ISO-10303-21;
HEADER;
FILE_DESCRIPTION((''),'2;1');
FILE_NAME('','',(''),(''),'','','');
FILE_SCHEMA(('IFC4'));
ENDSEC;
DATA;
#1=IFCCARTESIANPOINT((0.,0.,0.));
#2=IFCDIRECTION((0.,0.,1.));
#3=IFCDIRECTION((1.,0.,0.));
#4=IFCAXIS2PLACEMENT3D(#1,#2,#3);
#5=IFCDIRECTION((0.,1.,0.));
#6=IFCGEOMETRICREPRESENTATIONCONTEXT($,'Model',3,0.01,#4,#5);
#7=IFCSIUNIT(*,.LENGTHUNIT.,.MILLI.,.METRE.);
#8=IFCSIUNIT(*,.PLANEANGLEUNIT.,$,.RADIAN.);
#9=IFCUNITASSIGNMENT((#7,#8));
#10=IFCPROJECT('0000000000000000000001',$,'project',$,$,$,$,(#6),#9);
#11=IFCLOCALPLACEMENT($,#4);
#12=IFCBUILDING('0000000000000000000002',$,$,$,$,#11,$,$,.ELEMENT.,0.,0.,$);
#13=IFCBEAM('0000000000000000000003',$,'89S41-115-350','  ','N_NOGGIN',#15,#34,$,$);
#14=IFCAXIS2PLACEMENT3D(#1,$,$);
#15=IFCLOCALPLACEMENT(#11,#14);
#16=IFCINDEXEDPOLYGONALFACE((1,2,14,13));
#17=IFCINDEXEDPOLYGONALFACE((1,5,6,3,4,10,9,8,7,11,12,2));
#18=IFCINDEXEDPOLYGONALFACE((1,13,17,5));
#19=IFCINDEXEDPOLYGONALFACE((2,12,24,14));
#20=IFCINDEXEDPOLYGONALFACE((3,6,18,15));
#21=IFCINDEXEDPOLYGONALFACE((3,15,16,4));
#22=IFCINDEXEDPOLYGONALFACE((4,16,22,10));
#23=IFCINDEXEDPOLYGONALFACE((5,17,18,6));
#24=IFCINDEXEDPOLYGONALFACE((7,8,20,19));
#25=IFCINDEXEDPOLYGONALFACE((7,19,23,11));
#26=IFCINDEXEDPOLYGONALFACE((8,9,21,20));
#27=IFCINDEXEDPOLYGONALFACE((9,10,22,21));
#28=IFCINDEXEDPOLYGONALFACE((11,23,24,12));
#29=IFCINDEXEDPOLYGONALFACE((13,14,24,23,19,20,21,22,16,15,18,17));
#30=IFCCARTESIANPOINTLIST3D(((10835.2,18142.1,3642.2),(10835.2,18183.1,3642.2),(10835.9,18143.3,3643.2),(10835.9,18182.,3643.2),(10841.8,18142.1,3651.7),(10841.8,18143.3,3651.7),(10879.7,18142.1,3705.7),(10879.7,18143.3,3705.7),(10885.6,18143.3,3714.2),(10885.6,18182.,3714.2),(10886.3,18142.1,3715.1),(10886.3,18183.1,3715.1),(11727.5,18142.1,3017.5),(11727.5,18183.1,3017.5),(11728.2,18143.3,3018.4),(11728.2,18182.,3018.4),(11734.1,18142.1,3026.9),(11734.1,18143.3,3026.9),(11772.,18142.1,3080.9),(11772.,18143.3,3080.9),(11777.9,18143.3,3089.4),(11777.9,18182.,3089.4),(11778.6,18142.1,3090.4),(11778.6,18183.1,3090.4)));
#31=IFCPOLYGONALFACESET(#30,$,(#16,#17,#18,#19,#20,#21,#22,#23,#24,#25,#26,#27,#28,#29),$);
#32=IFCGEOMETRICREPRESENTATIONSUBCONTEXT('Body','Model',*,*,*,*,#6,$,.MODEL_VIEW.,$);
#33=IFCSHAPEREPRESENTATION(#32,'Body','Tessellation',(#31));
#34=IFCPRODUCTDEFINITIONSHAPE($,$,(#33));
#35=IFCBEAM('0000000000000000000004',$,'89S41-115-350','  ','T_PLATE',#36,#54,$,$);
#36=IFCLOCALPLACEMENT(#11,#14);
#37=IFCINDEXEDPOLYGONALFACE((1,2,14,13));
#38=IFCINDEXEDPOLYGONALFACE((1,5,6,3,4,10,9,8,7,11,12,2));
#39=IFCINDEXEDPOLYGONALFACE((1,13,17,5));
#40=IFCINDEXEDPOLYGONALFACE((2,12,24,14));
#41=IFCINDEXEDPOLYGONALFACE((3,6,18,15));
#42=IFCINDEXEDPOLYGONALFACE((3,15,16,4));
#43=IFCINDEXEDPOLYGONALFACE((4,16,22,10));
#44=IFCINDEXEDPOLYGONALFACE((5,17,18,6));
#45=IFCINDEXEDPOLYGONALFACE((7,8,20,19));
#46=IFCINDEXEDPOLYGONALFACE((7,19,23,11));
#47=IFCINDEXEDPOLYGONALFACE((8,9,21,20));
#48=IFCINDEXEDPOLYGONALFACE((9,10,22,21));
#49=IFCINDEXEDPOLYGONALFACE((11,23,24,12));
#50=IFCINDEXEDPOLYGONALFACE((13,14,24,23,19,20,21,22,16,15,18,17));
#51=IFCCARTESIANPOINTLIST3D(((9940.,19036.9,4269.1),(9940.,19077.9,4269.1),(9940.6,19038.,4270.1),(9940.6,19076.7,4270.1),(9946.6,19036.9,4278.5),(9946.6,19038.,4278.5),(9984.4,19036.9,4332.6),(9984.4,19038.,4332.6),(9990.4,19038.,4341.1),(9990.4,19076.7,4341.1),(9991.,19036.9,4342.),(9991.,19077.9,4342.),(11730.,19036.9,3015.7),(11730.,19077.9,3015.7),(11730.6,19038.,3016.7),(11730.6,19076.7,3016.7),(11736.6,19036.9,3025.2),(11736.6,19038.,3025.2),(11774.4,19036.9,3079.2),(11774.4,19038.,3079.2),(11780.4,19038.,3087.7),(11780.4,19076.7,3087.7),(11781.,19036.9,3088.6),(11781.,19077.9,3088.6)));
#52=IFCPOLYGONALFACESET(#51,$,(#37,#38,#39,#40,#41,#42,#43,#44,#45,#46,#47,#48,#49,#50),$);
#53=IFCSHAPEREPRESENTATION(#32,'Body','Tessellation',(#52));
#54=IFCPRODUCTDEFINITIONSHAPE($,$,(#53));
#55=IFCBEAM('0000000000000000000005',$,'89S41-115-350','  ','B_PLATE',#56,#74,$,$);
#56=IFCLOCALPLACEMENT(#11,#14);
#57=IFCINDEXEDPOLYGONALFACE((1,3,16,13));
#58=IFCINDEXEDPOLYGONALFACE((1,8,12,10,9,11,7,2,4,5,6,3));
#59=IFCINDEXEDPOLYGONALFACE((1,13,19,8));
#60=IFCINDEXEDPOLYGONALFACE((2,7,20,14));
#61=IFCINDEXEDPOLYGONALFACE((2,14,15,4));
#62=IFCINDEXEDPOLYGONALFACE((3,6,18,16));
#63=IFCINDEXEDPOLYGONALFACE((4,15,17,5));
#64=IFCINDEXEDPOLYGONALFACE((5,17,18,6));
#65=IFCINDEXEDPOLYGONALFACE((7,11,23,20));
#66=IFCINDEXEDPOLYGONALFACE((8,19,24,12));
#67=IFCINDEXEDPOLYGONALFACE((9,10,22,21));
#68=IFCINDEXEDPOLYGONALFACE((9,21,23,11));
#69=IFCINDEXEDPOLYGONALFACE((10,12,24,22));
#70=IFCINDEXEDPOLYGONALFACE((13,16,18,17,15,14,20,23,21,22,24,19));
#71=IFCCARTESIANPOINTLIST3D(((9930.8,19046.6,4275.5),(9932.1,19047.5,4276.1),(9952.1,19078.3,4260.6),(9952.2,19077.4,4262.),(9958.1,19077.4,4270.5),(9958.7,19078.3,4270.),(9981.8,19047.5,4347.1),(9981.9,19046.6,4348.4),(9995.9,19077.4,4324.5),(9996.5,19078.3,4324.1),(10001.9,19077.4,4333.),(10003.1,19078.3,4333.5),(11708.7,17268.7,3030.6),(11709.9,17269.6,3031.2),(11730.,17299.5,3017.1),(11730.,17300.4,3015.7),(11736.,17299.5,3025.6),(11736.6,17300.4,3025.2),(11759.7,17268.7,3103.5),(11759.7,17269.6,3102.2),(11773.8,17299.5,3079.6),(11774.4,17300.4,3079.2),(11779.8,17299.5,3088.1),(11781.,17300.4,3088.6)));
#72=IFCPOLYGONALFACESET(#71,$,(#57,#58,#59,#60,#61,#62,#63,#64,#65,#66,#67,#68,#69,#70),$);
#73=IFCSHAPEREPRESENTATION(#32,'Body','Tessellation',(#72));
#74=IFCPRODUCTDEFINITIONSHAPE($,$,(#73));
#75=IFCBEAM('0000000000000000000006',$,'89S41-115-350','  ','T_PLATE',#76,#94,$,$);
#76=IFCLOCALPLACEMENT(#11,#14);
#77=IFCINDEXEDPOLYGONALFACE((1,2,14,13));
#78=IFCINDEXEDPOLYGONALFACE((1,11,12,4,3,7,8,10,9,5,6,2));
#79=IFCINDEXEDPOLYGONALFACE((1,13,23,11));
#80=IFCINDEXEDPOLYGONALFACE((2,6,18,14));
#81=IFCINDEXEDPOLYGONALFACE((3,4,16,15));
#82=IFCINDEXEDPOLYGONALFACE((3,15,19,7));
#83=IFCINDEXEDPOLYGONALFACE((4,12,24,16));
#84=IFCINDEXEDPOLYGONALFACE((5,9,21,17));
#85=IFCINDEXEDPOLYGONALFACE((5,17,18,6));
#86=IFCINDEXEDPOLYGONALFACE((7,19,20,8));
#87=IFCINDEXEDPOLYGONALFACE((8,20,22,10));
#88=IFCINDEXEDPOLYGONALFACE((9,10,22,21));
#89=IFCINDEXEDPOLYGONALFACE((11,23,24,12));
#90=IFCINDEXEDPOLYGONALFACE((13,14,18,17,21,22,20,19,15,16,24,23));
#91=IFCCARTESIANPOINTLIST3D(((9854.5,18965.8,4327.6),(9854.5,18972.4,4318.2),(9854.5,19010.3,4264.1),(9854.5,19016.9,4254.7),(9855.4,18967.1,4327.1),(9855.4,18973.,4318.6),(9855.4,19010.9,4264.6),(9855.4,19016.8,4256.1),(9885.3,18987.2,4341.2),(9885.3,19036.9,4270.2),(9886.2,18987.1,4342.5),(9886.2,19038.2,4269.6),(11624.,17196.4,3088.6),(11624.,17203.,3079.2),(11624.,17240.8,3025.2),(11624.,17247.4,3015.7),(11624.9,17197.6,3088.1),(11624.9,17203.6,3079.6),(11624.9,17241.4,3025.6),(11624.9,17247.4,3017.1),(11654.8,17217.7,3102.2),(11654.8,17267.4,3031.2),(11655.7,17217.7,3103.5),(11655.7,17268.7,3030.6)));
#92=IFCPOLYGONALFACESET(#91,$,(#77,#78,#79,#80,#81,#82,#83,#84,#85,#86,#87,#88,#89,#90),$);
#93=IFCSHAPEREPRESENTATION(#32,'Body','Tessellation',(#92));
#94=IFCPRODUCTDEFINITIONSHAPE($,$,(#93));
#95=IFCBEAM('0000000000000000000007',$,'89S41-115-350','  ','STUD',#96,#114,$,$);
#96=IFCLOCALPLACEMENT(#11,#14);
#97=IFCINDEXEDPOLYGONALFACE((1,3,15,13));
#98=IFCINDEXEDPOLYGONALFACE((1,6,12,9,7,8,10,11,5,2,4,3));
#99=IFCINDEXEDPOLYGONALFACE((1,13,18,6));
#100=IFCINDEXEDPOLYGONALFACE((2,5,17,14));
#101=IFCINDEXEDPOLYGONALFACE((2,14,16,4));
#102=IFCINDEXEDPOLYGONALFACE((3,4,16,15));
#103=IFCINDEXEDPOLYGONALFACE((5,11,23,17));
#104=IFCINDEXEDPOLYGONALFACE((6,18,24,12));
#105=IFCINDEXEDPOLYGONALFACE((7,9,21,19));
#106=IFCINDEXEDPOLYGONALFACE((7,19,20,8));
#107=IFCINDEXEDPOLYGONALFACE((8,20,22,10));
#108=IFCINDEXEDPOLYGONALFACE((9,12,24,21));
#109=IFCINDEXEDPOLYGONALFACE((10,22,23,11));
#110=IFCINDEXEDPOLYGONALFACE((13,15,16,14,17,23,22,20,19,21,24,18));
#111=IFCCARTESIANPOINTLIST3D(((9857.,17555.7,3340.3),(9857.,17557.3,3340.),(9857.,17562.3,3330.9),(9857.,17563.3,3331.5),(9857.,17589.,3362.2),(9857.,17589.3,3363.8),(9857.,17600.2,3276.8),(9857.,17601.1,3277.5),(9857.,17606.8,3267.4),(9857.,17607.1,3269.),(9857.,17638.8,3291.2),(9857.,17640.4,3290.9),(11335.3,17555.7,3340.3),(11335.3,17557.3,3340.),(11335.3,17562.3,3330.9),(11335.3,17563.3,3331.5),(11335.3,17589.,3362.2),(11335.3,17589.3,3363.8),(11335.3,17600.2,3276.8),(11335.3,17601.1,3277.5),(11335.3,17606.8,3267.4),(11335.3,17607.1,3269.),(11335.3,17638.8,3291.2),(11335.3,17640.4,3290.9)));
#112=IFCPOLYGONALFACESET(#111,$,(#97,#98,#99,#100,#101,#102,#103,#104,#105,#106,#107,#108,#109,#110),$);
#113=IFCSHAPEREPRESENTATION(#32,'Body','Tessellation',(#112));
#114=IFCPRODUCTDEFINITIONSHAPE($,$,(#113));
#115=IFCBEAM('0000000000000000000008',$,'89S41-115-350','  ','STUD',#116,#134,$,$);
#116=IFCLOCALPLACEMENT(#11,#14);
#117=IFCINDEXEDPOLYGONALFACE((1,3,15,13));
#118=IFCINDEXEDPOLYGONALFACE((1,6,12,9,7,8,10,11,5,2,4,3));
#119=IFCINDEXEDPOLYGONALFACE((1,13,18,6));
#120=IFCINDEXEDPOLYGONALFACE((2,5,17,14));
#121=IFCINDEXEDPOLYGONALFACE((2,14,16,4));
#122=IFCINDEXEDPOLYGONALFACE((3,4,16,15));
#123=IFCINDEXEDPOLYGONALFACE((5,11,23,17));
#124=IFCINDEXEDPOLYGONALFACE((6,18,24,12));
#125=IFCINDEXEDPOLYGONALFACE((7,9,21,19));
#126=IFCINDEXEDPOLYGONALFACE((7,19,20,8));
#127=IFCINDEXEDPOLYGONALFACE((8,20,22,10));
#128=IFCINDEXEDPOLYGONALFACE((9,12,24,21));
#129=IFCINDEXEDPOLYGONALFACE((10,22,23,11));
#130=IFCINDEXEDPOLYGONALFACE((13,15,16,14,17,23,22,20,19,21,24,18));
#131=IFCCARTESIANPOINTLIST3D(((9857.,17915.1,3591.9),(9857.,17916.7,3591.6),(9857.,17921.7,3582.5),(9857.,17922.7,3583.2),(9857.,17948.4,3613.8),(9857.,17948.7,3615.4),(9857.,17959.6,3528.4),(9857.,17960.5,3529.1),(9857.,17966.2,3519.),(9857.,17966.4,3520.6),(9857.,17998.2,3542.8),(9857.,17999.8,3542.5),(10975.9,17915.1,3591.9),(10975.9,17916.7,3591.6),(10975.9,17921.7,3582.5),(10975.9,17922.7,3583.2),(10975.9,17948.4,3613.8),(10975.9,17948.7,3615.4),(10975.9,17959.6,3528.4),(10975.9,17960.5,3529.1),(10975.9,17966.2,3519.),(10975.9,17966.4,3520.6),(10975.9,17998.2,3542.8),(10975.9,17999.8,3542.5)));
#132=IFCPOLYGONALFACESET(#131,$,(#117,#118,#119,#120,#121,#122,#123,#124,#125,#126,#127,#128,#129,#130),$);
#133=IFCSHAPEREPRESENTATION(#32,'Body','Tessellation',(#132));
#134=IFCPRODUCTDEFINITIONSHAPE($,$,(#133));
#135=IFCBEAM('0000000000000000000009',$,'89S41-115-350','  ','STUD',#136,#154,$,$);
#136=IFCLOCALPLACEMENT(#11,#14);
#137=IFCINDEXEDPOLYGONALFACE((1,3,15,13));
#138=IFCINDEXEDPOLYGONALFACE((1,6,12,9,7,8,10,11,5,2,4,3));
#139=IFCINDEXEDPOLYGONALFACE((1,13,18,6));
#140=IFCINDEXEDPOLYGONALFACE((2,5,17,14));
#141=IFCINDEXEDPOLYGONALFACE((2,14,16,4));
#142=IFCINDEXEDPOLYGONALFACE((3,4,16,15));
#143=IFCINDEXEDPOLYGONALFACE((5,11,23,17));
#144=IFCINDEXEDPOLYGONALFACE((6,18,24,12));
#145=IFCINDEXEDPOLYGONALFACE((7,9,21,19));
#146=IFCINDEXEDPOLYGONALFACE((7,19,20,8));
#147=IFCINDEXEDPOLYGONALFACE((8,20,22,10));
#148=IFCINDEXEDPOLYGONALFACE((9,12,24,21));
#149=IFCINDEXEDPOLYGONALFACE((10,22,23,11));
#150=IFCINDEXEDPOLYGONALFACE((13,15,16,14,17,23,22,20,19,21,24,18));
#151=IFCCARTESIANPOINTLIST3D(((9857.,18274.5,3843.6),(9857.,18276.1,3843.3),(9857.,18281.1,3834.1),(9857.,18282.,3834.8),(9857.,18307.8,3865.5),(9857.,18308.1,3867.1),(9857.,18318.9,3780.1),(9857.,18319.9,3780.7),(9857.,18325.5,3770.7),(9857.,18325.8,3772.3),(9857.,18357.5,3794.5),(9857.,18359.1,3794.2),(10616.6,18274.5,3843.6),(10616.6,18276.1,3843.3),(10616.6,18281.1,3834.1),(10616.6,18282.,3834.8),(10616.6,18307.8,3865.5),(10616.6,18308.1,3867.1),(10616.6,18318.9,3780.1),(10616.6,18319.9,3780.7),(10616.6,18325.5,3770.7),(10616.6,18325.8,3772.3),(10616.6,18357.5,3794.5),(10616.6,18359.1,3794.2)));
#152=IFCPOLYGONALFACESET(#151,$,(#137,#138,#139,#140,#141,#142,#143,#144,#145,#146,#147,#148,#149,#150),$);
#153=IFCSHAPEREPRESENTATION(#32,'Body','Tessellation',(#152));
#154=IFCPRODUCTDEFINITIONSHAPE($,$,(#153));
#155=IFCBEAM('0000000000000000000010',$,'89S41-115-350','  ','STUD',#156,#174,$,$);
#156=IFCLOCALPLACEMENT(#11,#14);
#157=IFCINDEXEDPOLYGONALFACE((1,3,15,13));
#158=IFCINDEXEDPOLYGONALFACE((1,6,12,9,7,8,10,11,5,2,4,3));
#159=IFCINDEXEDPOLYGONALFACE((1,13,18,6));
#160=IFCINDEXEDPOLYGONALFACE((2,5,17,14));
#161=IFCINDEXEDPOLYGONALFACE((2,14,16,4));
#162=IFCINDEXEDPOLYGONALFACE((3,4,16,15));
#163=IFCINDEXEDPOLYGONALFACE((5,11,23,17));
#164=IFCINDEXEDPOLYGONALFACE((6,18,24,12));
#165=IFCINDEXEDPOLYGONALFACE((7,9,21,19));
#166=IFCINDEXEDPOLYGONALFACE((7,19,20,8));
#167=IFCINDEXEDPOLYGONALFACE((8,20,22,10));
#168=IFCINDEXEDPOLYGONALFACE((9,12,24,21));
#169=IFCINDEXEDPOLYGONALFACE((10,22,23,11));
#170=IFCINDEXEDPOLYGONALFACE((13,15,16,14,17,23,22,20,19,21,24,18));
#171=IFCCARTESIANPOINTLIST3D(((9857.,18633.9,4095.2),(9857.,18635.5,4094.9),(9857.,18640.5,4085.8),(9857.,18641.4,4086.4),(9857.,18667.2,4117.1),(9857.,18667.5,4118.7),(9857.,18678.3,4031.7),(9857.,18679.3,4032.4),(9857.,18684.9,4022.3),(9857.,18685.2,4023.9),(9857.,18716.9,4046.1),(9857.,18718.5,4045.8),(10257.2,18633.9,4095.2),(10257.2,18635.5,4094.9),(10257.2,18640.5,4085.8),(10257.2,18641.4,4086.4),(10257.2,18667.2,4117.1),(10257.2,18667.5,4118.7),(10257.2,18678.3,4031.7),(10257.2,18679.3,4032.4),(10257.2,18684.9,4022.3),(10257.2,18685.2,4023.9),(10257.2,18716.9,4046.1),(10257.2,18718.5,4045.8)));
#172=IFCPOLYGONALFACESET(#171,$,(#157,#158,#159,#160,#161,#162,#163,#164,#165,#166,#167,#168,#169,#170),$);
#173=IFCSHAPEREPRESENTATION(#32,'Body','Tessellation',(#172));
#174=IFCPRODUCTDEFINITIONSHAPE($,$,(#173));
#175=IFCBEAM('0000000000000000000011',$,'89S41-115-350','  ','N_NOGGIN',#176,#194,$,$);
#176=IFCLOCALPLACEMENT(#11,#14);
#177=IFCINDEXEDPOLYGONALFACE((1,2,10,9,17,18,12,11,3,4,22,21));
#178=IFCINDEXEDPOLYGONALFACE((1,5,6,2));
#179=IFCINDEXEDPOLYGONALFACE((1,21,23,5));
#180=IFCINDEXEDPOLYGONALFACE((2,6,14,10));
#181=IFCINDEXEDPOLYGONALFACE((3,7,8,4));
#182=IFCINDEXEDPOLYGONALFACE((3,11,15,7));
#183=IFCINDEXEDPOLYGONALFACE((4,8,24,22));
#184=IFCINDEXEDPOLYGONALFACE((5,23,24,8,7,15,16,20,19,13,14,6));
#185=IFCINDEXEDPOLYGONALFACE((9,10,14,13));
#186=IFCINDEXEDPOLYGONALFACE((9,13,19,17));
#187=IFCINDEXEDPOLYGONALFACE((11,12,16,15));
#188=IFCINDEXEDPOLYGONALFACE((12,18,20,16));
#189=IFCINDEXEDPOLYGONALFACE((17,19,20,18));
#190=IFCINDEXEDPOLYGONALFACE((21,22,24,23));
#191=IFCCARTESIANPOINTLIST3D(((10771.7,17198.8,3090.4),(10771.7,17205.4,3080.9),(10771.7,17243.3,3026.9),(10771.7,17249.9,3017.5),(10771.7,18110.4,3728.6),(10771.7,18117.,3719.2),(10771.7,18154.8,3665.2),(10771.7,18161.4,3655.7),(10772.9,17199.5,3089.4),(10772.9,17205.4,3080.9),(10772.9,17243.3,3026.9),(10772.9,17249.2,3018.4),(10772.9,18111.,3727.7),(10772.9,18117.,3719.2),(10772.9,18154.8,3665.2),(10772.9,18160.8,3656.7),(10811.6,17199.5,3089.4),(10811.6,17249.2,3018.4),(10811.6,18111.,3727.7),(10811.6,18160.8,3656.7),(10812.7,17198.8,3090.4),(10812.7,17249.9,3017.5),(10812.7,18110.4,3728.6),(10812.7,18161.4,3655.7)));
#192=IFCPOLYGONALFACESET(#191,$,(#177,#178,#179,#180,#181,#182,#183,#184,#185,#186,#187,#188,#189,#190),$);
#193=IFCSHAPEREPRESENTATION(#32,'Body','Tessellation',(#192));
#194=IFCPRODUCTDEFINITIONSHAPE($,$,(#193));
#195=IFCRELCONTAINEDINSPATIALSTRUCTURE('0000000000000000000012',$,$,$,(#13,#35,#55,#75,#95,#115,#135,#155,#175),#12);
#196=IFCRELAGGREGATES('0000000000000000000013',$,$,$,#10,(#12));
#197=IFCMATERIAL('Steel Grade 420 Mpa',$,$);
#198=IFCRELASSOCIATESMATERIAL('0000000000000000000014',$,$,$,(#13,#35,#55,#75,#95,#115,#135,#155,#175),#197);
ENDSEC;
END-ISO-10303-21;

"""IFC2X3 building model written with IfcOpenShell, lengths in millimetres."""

from ifc_helpers import new_model, si_unit, direction, frame, origin, origin_with_axes, origin_2d_with_axis, place, context, subcontext, project, spatial, c_section, extrude, source, transform, mapped, material, element, save


model = new_model("IFC2X3")

# Units and contexts
model_context = context("Model", 3, precision=0.01, world=origin_with_axes(), true_north=direction((0.0, 1.0, 0.0)))
body_context = subcontext(model_context, "Body", "Model", "MODEL_VIEW")
ifc_project = project(units=[si_unit("LENGTHUNIT", "METRE", prefix="MILLI"), si_unit("PLANEANGLEUNIT", "RADIAN")], contexts=[model_context])

# Building
building_placement = place(None, origin_with_axes())
building = spatial("IfcBuilding", under=ifc_project, at=building_placement, CompositionType="ELEMENT", ElevationOfRefHeight=0.0, ElevationOfTerrain=0.0)

# Shared definitions
ifc_material = material(Name="Steel Grade 420 Mpa")

# Beams
shared_shape_1 = source(origin(), body_context, "Body", "SweptSolid", [
    extrude(c_section(Depth=89.0, Width=41.0, WallThickness=1.1, Girth=11.5, at=origin_2d_with_axis()), origin_with_axes(), (0.0, 0.0, 1.0), 1089.3),
])
beam_1_placement = place(None, frame((10860.8, 18162.6, 3678.7), z_axis=(0.819152, 0.0, -0.573576), x_axis=(0.0, -1.0, 0.0)))
element("IfcBeam", 1, at=beam_1_placement, inside=building, material=ifc_material, Name="89S41-115-350", Description="  ", ObjectType="N_NOGGIN", context=body_context, shape_type="MappedRepresentation", body=[
    mapped(shared_shape_1, transform((0.0, 0.0, 0.0), scale=1.0)),
])
shared_shape_2 = source(origin(), body_context, "Body", "SweptSolid", [
    extrude(c_section(Depth=89.0, Width=41.0, WallThickness=1.1, Girth=11.5, at=origin_2d_with_axis()), origin_with_axes(), (0.0, 0.0, 1.0), 2185.2),
])
beam_2_placement = place(None, frame((9965.5, 19057.4, 4305.6), z_axis=(0.819152, 0.0, -0.573576), x_axis=(0.0, -1.0, 0.0)))
element("IfcBeam", 2, at=beam_2_placement, inside=building, material=ifc_material, Name="89S41-115-350", Description="  ", ObjectType="T_PLATE", context=body_context, shape_type="MappedRepresentation", body=[
    mapped(shared_shape_2, transform((0.0, 0.0, 0.0), scale=1.0)),
])
shared_shape_3 = source(origin(), body_context, "Body", "SweptSolid", [
    extrude(c_section(Depth=89.0, Width=41.0, WallThickness=1.1, Girth=11.5, at=origin_2d_with_axis()), origin_with_axes(), (0.0, 0.0, 1.0), 2805.6),
])
beam_3_placement = place(None, frame((9967.0, 19062.4, 4304.5), z_axis=(0.633687, -0.633687, -0.443713), x_axis=(0.519086, 0.773589, -0.363468)))
element("IfcBeam", 3, at=beam_3_placement, inside=building, material=ifc_material, Name="89S41-115-350", Description="  ", ObjectType="B_PLATE", context=body_context, shape_type="MappedRepresentation", body=[
    mapped(shared_shape_3, transform((0.0, 0.0, 0.0), scale=1.0)),
])
shared_shape_4 = source(origin(), body_context, "Body", "SweptSolid", [
    extrude(c_section(Depth=89.0, Width=41.0, WallThickness=1.1, Girth=11.5, at=origin_2d_with_axis()), origin_with_axes(), (0.0, 0.0, 1.0), 2792.3),
])
beam_4_placement = place(None, frame((9870.4, 19002.0, 4298.6), z_axis=(0.633687, -0.633687, -0.443713), x_axis=(-0.773589, -0.519086, -0.363468)))
element("IfcBeam", 4, at=beam_4_placement, inside=building, material=ifc_material, Name="89S41-115-350", Description="  ", ObjectType="T_PLATE", context=body_context, shape_type="MappedRepresentation", body=[
    mapped(shared_shape_4, transform((0.0, 0.0, 0.0), scale=1.0)),
])
shared_shape_5 = source(origin(), body_context, "Body", "SweptSolid", [
    extrude(c_section(Depth=89.0, Width=41.0, WallThickness=1.1, Girth=11.5, at=origin_2d_with_axis()), origin_with_axes(), (0.0, 0.0, 1.0), 1478.3),
])
beam_5_placement = place(None, frame((9857.0, 17598.1, 3315.6), z_axis=(1.0, 0.0, 0.0), x_axis=(0.0, -0.819152, -0.573576)))
element("IfcBeam", 5, at=beam_5_placement, inside=building, material=ifc_material, Name="89S41-115-350", Description="  ", ObjectType="STUD", context=body_context, shape_type="MappedRepresentation", body=[
    mapped(shared_shape_5, transform((0.0, 0.0, 0.0), scale=1.0)),
])
shared_shape_6 = source(origin(), body_context, "Body", "SweptSolid", [
    extrude(c_section(Depth=89.0, Width=41.0, WallThickness=1.1, Girth=11.5, at=origin_2d_with_axis()), origin_with_axes(), (0.0, 0.0, 1.0), 1118.9),
])
beam_6_placement = place(None, frame((9857.0, 17957.4, 3567.2), z_axis=(1.0, 0.0, 0.0), x_axis=(0.0, -0.819152, -0.573576)))
element("IfcBeam", 6, at=beam_6_placement, inside=building, material=ifc_material, Name="89S41-115-350", Description="  ", ObjectType="STUD", context=body_context, shape_type="MappedRepresentation", body=[
    mapped(shared_shape_6, transform((0.0, 0.0, 0.0), scale=1.0)),
])
shared_shape_7 = source(origin(), body_context, "Body", "SweptSolid", [
    extrude(c_section(Depth=89.0, Width=41.0, WallThickness=1.1, Girth=11.5, at=origin_2d_with_axis()), origin_with_axes(), (0.0, 0.0, 1.0), 759.5),
])
beam_7_placement = place(None, frame((9857.0, 18316.8, 3818.9), z_axis=(1.0, 0.0, 0.0), x_axis=(0.0, -0.819152, -0.573576)))
element("IfcBeam", 7, at=beam_7_placement, inside=building, material=ifc_material, Name="89S41-115-350", Description="  ", ObjectType="STUD", context=body_context, shape_type="MappedRepresentation", body=[
    mapped(shared_shape_7, transform((0.0, 0.0, 0.0), scale=1.0)),
])
shared_shape_8 = source(origin(), body_context, "Body", "SweptSolid", [
    extrude(c_section(Depth=89.0, Width=41.0, WallThickness=1.1, Girth=11.5, at=origin_2d_with_axis()), origin_with_axes(), (0.0, 0.0, 1.0), 400.2),
])
beam_8_placement = place(None, frame((9857.0, 18676.2, 4070.5), z_axis=(1.0, 0.0, 0.0), x_axis=(0.0, -0.819152, -0.573576)))
element("IfcBeam", 8, at=beam_8_placement, inside=building, material=ifc_material, Name="89S41-115-350", Description="  ", ObjectType="STUD", context=body_context, shape_type="MappedRepresentation", body=[
    mapped(shared_shape_8, transform((0.0, 0.0, 0.0), scale=1.0)),
])
shared_shape_9 = source(origin(), body_context, "Body", "SweptSolid", [
    extrude(c_section(Depth=89.0, Width=41.0, WallThickness=1.1, Girth=11.5, at=origin_2d_with_axis()), origin_with_axes(), (0.0, 0.0, 1.0), 1112.8),
])
beam_9_placement = place(None, frame((10792.2, 18135.9, 3692.2), z_axis=(0.0, -0.819152, -0.573576), x_axis=(-1.0, 0.0, 0.0)))
element("IfcBeam", 9, at=beam_9_placement, inside=building, material=ifc_material, Name="89S41-115-350", Description="  ", ObjectType="N_NOGGIN", context=body_context, shape_type="MappedRepresentation", body=[
    mapped(shared_shape_9, transform((0.0, 0.0, 0.0), scale=1.0)),
])

save(model, "model.ifc")
